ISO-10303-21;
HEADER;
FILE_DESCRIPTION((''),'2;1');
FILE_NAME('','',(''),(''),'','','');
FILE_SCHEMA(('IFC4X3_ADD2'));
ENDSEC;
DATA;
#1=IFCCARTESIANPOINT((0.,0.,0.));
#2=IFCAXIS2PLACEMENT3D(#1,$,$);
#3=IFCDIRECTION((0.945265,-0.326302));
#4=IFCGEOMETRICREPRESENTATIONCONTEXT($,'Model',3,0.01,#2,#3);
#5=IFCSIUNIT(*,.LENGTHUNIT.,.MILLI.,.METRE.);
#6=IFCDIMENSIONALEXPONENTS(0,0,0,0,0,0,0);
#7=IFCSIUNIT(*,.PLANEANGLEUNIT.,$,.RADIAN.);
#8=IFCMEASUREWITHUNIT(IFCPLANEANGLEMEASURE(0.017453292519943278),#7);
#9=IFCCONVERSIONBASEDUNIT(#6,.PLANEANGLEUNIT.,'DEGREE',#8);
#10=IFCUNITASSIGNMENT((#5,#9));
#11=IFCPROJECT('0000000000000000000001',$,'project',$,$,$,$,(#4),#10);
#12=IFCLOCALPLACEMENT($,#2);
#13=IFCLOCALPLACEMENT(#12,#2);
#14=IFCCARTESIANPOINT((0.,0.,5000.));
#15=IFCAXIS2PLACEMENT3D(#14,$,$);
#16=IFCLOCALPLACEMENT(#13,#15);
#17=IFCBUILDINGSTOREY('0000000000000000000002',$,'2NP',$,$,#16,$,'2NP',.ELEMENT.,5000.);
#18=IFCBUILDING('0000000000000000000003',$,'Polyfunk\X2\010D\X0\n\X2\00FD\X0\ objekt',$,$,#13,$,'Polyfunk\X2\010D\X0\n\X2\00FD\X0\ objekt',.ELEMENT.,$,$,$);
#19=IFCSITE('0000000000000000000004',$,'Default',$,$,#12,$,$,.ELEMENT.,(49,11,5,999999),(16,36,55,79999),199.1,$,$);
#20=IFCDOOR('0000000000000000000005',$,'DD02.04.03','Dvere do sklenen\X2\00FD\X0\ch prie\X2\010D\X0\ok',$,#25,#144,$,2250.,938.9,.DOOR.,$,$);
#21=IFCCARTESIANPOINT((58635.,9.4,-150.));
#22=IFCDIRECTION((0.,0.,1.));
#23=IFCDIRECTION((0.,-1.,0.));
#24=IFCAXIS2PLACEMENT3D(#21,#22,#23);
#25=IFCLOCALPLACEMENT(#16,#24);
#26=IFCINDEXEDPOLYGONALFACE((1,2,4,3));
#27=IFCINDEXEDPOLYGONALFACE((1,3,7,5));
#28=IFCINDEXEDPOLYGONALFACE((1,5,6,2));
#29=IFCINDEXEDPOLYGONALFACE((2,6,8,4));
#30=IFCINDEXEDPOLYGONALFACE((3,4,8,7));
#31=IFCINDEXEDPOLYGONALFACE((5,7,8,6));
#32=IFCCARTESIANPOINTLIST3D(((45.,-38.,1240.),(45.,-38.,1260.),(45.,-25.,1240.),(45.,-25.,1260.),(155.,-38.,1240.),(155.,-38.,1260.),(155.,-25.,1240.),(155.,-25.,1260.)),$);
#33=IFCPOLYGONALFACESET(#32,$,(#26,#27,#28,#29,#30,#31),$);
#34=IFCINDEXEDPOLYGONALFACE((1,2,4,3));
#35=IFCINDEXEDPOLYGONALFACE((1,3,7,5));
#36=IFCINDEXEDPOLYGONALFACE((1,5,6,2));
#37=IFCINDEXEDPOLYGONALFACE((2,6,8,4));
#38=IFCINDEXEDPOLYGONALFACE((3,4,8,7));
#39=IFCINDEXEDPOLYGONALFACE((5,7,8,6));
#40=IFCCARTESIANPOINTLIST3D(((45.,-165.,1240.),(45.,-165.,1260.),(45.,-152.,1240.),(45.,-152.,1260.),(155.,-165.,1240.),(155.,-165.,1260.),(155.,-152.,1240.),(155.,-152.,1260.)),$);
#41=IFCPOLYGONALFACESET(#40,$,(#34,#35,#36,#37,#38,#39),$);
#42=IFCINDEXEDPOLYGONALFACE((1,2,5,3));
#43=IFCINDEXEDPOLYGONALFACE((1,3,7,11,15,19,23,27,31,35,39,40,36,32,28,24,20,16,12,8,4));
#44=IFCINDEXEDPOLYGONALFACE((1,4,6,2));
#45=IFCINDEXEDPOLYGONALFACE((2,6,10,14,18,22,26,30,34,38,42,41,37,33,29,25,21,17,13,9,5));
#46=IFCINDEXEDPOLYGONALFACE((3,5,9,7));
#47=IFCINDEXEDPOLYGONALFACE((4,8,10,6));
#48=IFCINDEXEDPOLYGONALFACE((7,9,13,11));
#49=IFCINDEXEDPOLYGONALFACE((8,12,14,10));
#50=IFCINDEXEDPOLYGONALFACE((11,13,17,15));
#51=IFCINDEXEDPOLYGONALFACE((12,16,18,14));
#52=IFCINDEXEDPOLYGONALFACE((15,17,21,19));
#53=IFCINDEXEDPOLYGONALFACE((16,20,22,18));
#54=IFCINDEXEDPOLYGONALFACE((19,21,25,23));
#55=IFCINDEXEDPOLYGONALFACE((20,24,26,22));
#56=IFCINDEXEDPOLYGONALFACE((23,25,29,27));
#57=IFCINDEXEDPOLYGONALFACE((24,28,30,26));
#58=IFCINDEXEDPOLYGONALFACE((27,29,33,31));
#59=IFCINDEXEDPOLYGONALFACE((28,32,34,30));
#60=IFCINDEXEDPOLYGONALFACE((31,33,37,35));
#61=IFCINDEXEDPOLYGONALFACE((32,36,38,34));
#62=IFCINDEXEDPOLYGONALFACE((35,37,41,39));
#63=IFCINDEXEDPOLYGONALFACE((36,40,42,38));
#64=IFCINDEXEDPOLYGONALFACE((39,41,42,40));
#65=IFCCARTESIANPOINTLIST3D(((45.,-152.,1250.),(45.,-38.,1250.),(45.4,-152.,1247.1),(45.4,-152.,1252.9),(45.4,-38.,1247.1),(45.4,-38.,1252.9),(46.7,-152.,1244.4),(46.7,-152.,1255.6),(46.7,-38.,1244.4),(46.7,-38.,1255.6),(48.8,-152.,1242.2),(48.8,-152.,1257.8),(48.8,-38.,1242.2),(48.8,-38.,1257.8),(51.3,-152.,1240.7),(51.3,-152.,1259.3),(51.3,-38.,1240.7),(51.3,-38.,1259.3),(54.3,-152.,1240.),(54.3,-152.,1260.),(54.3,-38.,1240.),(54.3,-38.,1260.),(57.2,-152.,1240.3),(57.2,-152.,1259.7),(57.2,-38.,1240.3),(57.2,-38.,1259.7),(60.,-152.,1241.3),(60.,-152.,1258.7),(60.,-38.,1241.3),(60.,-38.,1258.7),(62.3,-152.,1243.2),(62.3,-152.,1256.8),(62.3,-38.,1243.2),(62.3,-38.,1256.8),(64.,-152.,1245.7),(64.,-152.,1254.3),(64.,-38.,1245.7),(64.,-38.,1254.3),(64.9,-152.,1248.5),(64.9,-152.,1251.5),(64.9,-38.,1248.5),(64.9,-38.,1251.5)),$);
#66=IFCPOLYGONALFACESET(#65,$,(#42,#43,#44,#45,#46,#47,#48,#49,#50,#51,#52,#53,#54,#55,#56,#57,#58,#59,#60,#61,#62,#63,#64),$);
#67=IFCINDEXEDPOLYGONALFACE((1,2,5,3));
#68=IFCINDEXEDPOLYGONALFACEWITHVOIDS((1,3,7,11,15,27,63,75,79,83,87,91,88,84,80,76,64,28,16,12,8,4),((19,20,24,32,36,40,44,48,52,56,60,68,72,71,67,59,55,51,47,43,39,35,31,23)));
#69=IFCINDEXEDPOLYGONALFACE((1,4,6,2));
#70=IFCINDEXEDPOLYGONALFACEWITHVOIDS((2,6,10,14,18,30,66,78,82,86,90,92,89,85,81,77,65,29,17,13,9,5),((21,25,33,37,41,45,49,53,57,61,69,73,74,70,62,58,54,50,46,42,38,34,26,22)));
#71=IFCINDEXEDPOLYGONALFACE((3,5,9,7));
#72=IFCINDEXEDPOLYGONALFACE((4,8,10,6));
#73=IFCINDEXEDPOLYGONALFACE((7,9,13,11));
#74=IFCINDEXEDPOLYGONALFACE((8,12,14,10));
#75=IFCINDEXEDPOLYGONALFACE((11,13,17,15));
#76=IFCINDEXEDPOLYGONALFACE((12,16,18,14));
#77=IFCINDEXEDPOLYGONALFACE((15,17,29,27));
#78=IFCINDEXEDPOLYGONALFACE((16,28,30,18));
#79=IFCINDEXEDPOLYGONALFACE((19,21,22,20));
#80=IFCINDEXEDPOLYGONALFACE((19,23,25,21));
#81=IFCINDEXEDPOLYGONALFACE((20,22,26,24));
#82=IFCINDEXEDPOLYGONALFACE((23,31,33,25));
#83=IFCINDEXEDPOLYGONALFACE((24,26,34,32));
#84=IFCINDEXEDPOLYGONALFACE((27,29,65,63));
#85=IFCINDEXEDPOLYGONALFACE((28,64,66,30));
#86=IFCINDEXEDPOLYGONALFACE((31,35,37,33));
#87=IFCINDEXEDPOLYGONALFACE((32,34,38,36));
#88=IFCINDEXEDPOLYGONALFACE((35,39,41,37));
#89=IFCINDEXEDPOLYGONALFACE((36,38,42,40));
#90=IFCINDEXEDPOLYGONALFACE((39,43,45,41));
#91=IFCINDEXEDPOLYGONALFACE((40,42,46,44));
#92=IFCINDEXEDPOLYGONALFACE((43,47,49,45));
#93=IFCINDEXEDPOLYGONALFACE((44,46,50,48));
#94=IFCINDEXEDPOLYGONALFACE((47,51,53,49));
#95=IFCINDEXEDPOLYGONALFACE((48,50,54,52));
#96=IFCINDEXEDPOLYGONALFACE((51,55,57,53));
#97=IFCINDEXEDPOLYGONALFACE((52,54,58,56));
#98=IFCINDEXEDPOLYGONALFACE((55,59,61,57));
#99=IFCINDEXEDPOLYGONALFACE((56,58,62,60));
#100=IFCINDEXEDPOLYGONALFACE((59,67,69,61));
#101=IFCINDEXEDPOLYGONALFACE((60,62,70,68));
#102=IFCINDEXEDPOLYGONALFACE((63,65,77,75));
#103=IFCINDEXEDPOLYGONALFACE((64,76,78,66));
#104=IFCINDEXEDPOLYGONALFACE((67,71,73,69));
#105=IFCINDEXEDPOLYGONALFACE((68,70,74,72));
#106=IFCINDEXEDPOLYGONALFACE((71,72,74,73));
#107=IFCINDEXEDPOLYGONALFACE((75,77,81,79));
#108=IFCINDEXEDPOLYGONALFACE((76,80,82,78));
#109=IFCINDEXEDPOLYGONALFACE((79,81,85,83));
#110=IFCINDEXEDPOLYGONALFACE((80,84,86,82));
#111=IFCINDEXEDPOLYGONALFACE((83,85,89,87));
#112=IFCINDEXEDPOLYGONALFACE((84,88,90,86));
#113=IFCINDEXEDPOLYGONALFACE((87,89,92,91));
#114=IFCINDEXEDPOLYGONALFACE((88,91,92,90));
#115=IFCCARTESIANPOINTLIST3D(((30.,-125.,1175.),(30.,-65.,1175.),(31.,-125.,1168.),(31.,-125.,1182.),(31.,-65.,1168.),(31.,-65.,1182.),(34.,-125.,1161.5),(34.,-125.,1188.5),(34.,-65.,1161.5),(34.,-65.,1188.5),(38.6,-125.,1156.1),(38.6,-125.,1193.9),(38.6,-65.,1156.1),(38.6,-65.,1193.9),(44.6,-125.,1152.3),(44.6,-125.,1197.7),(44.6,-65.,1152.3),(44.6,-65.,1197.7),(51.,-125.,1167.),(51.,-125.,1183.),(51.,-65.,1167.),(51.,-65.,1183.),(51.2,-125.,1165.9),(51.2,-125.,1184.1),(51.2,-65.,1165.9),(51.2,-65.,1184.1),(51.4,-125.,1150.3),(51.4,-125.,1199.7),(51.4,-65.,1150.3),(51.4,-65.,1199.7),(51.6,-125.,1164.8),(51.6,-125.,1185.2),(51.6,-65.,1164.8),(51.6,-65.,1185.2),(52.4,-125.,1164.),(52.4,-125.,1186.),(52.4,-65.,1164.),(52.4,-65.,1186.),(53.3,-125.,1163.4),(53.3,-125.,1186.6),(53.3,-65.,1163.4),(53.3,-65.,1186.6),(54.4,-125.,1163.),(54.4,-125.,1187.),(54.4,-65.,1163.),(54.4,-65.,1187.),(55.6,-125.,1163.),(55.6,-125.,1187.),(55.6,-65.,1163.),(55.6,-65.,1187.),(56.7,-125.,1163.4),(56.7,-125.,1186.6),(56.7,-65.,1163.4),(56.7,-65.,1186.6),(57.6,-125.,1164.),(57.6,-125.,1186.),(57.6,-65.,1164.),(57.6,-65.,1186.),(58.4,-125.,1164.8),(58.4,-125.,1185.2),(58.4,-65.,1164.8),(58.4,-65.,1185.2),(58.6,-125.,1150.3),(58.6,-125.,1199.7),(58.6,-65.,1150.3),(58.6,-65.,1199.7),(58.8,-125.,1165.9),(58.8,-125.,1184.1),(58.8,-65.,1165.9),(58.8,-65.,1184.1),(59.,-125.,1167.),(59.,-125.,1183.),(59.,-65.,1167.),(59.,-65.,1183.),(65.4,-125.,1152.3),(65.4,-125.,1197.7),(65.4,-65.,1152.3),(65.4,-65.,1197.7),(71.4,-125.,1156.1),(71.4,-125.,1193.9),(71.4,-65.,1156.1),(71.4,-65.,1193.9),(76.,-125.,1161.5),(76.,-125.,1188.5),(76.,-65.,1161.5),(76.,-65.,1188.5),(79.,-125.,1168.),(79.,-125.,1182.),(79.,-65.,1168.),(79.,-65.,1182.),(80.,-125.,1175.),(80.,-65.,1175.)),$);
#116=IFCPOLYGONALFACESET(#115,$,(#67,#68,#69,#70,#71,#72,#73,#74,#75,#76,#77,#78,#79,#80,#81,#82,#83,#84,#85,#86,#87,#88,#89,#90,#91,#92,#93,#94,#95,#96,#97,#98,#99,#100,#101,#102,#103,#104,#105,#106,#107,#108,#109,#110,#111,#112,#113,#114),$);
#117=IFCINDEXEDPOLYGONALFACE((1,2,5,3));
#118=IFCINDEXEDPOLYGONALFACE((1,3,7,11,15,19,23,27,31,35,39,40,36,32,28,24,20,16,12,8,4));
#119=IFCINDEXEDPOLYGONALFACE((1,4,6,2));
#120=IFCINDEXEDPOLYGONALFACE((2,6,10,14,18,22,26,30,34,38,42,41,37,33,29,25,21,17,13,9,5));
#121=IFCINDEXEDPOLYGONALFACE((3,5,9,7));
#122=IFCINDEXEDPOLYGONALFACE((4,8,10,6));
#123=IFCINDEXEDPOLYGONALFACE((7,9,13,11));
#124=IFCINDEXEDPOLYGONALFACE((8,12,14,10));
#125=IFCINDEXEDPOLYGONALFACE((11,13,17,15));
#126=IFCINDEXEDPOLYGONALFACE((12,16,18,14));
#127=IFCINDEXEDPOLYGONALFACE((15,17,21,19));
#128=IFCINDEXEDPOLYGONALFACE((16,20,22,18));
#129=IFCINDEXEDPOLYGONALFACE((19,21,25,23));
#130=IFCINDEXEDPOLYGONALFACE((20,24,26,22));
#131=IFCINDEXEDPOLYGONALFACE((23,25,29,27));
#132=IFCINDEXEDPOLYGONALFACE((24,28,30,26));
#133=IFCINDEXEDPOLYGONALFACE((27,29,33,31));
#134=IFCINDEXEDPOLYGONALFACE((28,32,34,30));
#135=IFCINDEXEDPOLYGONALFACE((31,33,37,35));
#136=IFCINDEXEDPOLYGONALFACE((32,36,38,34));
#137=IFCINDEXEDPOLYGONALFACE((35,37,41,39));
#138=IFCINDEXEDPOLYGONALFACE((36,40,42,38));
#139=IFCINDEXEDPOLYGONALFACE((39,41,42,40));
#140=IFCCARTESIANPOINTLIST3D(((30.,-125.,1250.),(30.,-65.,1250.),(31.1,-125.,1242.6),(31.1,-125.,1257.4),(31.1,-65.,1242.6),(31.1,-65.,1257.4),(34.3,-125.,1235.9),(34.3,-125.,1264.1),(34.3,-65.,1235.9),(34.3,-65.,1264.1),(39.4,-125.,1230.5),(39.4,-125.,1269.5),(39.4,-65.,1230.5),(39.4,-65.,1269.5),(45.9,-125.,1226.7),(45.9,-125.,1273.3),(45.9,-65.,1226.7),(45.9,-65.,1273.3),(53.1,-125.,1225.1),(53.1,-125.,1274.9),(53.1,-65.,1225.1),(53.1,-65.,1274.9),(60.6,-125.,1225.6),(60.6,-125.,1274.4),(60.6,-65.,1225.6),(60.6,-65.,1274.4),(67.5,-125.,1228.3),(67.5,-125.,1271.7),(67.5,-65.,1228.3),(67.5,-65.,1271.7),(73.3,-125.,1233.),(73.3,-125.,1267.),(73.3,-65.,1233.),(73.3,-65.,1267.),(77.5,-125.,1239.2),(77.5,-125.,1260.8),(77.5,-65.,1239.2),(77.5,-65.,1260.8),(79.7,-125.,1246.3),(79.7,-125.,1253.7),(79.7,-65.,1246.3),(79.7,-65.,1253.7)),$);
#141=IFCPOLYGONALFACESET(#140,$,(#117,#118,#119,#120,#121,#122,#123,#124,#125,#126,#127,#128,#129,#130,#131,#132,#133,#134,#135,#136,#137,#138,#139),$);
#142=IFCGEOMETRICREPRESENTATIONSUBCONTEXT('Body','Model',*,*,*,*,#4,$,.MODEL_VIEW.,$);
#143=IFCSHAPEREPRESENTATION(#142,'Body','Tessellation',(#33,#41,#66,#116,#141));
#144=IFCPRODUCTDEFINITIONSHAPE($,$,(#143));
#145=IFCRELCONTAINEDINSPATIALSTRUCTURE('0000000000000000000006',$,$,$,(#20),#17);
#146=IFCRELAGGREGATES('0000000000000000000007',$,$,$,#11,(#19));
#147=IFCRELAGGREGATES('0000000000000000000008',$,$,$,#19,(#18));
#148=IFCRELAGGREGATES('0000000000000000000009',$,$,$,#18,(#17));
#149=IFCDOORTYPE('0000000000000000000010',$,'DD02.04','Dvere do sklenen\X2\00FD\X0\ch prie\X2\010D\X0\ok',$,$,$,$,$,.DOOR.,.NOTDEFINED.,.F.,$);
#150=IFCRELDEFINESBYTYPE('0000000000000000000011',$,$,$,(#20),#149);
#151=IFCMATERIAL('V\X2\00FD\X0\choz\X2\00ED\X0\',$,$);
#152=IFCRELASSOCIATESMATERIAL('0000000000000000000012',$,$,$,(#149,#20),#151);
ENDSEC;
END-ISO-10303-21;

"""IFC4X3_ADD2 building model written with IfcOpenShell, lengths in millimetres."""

from ifc_helpers import new_model, entity, si_unit, converted_unit, direction, frame, frame_2d, origin, origin_2d_with_axis, place, context, subcontext, project, spatial, polyline, circle_curve, parameter, trimmed, segment, composite_curve, rectangle, circle, outline, extrude, source, transform, mapped, material, type_object, type_shapes, element, save


model = new_model("IFC4X3_ADD2")

# Units and contexts
model_context = context("Model", 3, precision=0.01, world=origin(), true_north=direction((0.945265, -0.326302)))
body_context = subcontext(model_context, "Body", "Model", "MODEL_VIEW")
ifc_project = project(units=[si_unit("LENGTHUNIT", "METRE", prefix="MILLI"), converted_unit("PLANEANGLEUNIT", "DEGREE", entity("IfcPlaneAngleMeasure", 0.017453292519943278), si_unit("PLANEANGLEUNIT", "RADIAN"), dimensions=[0, 0, 0, 0, 0, 0, 0])], contexts=[model_context])

# Site, building, storey
site_placement = place(None, origin())
site = spatial("IfcSite", under=ifc_project, at=site_placement, Name="Default", CompositionType="ELEMENT", RefLatitude=(49, 11, 5, 999999), RefLongitude=(16, 36, 55, 79999), RefElevation=199.1)
building_placement = place(site_placement, origin())
building = spatial("IfcBuilding", under=site, at=building_placement, Name="Polyfunkčný objekt", LongName="Polyfunkčný objekt", CompositionType="ELEMENT")
storey_placement = place(building_placement, frame((0.0, 0.0, 5000.0)))
storey = spatial("IfcBuildingStorey", under=building, at=storey_placement, Name="2NP", LongName="2NP", CompositionType="ELEMENT", Elevation=5000.0)

# Door
ifc_material_1 = material(Name="Výchozí")
door_type = type_object("IfcDoorType", Name="DD02.04", Description="Dvere do sklenených priečok", OperationType="NOTDEFINED", ParameterTakesPrecedence=False, PredefinedType="DOOR", material=ifc_material_1)
shared_shape_1 = source(origin(), body_context, "Body", "SweptSolid", [
    extrude(rectangle(XDim=110.0, YDim=13.0, at=frame_2d((0.0, 0.0), x_axis=(1.0, 0.0))), frame((100.0, -31.5, 1240.0)), (0.0, 0.0, 1.0), 20.0),
    extrude(rectangle(XDim=110.0, YDim=13.0, at=origin_2d_with_axis()), frame((100.0, -158.5, 1240.0), z_axis=(0.0, 0.0, 1.0), x_axis=(-1.0, 0.0, 0.0)), (0.0, 0.0, 1.0), 20.0),
    extrude(circle(Radius=10.0, at=origin_2d_with_axis()), frame((55.0, -152.0, 1250.0), z_axis=(0.0, 1.0, 0.0), x_axis=(-1.0, 0.0, 0.0)), (0.0, 0.0, 1.0), 114.0),
    extrude(outline(composite_curve([segment(trimmed(circle_curve(origin_2d_with_axis(), 25.0), [parameter(180.0)], [parameter(360.0)], True, "PARAMETER"), True, "CONTINUOUS"), segment(trimmed(circle_curve(origin_2d_with_axis(), 25.0), [parameter(0.0)], [parameter(180.0)], True, "PARAMETER"), True, "CONTINUOUS")], self_intersect=False), holes=[composite_curve([segment(trimmed(circle_curve(frame_2d((0.0, 8.0), x_axis=(1.0, 0.0)), 4.0), [parameter(0.0)], [parameter(180.0)], True, "PARAMETER"), False, "CONTINUOUS"), segment(polyline([(4.0, 8.0), (4.0, -8.0)]), True, "CONTINUOUS"), segment(trimmed(circle_curve(frame_2d((0.0, -8.0), x_axis=(1.0, 0.0)), 4.0), [parameter(180.0)], [parameter(0.0)], True, "PARAMETER"), False, "CONTINUOUS"), segment(polyline([(-4.0, -8.0), (-4.0, 8.0)]), True, "CONTINUOUS")], self_intersect=False)]), frame((55.0, -125.0, 1175.0), z_axis=(0.0, 1.0, 0.0), x_axis=(-1.0, 0.0, 0.0)), (0.0, 0.0, 1.0), 60.0),
    extrude(circle(Radius=25.0, at=frame_2d((0.0, 0.0), x_axis=(1.0, 0.0))), frame((55.0, -125.0, 1250.0), z_axis=(0.0, 1.0, 0.0), x_axis=(-1.0, 0.0, 0.0)), (0.0, 0.0, 1.0), 60.0),
])
type_shapes(door_type, [shared_shape_1])
door_placement = place(storey_placement, frame((58635.0, 9.4, -150.0), z_axis=(0.0, 0.0, 1.0), x_axis=(0.0, -1.0, 0.0)))
element("IfcDoor", 1, at=door_placement, inside=storey, type_object=door_type, material=ifc_material_1, Name="DD02.04.03", Description="Dvere do sklenených priečok", OverallHeight=2250.0, OverallWidth=938.9, PredefinedType="DOOR", context=body_context, shape_type="MappedRepresentation", body=[
    mapped(shared_shape_1, transform((0.0, 0.0, 0.0), scale=1.0)),
])

save(model, "model.ifc")
